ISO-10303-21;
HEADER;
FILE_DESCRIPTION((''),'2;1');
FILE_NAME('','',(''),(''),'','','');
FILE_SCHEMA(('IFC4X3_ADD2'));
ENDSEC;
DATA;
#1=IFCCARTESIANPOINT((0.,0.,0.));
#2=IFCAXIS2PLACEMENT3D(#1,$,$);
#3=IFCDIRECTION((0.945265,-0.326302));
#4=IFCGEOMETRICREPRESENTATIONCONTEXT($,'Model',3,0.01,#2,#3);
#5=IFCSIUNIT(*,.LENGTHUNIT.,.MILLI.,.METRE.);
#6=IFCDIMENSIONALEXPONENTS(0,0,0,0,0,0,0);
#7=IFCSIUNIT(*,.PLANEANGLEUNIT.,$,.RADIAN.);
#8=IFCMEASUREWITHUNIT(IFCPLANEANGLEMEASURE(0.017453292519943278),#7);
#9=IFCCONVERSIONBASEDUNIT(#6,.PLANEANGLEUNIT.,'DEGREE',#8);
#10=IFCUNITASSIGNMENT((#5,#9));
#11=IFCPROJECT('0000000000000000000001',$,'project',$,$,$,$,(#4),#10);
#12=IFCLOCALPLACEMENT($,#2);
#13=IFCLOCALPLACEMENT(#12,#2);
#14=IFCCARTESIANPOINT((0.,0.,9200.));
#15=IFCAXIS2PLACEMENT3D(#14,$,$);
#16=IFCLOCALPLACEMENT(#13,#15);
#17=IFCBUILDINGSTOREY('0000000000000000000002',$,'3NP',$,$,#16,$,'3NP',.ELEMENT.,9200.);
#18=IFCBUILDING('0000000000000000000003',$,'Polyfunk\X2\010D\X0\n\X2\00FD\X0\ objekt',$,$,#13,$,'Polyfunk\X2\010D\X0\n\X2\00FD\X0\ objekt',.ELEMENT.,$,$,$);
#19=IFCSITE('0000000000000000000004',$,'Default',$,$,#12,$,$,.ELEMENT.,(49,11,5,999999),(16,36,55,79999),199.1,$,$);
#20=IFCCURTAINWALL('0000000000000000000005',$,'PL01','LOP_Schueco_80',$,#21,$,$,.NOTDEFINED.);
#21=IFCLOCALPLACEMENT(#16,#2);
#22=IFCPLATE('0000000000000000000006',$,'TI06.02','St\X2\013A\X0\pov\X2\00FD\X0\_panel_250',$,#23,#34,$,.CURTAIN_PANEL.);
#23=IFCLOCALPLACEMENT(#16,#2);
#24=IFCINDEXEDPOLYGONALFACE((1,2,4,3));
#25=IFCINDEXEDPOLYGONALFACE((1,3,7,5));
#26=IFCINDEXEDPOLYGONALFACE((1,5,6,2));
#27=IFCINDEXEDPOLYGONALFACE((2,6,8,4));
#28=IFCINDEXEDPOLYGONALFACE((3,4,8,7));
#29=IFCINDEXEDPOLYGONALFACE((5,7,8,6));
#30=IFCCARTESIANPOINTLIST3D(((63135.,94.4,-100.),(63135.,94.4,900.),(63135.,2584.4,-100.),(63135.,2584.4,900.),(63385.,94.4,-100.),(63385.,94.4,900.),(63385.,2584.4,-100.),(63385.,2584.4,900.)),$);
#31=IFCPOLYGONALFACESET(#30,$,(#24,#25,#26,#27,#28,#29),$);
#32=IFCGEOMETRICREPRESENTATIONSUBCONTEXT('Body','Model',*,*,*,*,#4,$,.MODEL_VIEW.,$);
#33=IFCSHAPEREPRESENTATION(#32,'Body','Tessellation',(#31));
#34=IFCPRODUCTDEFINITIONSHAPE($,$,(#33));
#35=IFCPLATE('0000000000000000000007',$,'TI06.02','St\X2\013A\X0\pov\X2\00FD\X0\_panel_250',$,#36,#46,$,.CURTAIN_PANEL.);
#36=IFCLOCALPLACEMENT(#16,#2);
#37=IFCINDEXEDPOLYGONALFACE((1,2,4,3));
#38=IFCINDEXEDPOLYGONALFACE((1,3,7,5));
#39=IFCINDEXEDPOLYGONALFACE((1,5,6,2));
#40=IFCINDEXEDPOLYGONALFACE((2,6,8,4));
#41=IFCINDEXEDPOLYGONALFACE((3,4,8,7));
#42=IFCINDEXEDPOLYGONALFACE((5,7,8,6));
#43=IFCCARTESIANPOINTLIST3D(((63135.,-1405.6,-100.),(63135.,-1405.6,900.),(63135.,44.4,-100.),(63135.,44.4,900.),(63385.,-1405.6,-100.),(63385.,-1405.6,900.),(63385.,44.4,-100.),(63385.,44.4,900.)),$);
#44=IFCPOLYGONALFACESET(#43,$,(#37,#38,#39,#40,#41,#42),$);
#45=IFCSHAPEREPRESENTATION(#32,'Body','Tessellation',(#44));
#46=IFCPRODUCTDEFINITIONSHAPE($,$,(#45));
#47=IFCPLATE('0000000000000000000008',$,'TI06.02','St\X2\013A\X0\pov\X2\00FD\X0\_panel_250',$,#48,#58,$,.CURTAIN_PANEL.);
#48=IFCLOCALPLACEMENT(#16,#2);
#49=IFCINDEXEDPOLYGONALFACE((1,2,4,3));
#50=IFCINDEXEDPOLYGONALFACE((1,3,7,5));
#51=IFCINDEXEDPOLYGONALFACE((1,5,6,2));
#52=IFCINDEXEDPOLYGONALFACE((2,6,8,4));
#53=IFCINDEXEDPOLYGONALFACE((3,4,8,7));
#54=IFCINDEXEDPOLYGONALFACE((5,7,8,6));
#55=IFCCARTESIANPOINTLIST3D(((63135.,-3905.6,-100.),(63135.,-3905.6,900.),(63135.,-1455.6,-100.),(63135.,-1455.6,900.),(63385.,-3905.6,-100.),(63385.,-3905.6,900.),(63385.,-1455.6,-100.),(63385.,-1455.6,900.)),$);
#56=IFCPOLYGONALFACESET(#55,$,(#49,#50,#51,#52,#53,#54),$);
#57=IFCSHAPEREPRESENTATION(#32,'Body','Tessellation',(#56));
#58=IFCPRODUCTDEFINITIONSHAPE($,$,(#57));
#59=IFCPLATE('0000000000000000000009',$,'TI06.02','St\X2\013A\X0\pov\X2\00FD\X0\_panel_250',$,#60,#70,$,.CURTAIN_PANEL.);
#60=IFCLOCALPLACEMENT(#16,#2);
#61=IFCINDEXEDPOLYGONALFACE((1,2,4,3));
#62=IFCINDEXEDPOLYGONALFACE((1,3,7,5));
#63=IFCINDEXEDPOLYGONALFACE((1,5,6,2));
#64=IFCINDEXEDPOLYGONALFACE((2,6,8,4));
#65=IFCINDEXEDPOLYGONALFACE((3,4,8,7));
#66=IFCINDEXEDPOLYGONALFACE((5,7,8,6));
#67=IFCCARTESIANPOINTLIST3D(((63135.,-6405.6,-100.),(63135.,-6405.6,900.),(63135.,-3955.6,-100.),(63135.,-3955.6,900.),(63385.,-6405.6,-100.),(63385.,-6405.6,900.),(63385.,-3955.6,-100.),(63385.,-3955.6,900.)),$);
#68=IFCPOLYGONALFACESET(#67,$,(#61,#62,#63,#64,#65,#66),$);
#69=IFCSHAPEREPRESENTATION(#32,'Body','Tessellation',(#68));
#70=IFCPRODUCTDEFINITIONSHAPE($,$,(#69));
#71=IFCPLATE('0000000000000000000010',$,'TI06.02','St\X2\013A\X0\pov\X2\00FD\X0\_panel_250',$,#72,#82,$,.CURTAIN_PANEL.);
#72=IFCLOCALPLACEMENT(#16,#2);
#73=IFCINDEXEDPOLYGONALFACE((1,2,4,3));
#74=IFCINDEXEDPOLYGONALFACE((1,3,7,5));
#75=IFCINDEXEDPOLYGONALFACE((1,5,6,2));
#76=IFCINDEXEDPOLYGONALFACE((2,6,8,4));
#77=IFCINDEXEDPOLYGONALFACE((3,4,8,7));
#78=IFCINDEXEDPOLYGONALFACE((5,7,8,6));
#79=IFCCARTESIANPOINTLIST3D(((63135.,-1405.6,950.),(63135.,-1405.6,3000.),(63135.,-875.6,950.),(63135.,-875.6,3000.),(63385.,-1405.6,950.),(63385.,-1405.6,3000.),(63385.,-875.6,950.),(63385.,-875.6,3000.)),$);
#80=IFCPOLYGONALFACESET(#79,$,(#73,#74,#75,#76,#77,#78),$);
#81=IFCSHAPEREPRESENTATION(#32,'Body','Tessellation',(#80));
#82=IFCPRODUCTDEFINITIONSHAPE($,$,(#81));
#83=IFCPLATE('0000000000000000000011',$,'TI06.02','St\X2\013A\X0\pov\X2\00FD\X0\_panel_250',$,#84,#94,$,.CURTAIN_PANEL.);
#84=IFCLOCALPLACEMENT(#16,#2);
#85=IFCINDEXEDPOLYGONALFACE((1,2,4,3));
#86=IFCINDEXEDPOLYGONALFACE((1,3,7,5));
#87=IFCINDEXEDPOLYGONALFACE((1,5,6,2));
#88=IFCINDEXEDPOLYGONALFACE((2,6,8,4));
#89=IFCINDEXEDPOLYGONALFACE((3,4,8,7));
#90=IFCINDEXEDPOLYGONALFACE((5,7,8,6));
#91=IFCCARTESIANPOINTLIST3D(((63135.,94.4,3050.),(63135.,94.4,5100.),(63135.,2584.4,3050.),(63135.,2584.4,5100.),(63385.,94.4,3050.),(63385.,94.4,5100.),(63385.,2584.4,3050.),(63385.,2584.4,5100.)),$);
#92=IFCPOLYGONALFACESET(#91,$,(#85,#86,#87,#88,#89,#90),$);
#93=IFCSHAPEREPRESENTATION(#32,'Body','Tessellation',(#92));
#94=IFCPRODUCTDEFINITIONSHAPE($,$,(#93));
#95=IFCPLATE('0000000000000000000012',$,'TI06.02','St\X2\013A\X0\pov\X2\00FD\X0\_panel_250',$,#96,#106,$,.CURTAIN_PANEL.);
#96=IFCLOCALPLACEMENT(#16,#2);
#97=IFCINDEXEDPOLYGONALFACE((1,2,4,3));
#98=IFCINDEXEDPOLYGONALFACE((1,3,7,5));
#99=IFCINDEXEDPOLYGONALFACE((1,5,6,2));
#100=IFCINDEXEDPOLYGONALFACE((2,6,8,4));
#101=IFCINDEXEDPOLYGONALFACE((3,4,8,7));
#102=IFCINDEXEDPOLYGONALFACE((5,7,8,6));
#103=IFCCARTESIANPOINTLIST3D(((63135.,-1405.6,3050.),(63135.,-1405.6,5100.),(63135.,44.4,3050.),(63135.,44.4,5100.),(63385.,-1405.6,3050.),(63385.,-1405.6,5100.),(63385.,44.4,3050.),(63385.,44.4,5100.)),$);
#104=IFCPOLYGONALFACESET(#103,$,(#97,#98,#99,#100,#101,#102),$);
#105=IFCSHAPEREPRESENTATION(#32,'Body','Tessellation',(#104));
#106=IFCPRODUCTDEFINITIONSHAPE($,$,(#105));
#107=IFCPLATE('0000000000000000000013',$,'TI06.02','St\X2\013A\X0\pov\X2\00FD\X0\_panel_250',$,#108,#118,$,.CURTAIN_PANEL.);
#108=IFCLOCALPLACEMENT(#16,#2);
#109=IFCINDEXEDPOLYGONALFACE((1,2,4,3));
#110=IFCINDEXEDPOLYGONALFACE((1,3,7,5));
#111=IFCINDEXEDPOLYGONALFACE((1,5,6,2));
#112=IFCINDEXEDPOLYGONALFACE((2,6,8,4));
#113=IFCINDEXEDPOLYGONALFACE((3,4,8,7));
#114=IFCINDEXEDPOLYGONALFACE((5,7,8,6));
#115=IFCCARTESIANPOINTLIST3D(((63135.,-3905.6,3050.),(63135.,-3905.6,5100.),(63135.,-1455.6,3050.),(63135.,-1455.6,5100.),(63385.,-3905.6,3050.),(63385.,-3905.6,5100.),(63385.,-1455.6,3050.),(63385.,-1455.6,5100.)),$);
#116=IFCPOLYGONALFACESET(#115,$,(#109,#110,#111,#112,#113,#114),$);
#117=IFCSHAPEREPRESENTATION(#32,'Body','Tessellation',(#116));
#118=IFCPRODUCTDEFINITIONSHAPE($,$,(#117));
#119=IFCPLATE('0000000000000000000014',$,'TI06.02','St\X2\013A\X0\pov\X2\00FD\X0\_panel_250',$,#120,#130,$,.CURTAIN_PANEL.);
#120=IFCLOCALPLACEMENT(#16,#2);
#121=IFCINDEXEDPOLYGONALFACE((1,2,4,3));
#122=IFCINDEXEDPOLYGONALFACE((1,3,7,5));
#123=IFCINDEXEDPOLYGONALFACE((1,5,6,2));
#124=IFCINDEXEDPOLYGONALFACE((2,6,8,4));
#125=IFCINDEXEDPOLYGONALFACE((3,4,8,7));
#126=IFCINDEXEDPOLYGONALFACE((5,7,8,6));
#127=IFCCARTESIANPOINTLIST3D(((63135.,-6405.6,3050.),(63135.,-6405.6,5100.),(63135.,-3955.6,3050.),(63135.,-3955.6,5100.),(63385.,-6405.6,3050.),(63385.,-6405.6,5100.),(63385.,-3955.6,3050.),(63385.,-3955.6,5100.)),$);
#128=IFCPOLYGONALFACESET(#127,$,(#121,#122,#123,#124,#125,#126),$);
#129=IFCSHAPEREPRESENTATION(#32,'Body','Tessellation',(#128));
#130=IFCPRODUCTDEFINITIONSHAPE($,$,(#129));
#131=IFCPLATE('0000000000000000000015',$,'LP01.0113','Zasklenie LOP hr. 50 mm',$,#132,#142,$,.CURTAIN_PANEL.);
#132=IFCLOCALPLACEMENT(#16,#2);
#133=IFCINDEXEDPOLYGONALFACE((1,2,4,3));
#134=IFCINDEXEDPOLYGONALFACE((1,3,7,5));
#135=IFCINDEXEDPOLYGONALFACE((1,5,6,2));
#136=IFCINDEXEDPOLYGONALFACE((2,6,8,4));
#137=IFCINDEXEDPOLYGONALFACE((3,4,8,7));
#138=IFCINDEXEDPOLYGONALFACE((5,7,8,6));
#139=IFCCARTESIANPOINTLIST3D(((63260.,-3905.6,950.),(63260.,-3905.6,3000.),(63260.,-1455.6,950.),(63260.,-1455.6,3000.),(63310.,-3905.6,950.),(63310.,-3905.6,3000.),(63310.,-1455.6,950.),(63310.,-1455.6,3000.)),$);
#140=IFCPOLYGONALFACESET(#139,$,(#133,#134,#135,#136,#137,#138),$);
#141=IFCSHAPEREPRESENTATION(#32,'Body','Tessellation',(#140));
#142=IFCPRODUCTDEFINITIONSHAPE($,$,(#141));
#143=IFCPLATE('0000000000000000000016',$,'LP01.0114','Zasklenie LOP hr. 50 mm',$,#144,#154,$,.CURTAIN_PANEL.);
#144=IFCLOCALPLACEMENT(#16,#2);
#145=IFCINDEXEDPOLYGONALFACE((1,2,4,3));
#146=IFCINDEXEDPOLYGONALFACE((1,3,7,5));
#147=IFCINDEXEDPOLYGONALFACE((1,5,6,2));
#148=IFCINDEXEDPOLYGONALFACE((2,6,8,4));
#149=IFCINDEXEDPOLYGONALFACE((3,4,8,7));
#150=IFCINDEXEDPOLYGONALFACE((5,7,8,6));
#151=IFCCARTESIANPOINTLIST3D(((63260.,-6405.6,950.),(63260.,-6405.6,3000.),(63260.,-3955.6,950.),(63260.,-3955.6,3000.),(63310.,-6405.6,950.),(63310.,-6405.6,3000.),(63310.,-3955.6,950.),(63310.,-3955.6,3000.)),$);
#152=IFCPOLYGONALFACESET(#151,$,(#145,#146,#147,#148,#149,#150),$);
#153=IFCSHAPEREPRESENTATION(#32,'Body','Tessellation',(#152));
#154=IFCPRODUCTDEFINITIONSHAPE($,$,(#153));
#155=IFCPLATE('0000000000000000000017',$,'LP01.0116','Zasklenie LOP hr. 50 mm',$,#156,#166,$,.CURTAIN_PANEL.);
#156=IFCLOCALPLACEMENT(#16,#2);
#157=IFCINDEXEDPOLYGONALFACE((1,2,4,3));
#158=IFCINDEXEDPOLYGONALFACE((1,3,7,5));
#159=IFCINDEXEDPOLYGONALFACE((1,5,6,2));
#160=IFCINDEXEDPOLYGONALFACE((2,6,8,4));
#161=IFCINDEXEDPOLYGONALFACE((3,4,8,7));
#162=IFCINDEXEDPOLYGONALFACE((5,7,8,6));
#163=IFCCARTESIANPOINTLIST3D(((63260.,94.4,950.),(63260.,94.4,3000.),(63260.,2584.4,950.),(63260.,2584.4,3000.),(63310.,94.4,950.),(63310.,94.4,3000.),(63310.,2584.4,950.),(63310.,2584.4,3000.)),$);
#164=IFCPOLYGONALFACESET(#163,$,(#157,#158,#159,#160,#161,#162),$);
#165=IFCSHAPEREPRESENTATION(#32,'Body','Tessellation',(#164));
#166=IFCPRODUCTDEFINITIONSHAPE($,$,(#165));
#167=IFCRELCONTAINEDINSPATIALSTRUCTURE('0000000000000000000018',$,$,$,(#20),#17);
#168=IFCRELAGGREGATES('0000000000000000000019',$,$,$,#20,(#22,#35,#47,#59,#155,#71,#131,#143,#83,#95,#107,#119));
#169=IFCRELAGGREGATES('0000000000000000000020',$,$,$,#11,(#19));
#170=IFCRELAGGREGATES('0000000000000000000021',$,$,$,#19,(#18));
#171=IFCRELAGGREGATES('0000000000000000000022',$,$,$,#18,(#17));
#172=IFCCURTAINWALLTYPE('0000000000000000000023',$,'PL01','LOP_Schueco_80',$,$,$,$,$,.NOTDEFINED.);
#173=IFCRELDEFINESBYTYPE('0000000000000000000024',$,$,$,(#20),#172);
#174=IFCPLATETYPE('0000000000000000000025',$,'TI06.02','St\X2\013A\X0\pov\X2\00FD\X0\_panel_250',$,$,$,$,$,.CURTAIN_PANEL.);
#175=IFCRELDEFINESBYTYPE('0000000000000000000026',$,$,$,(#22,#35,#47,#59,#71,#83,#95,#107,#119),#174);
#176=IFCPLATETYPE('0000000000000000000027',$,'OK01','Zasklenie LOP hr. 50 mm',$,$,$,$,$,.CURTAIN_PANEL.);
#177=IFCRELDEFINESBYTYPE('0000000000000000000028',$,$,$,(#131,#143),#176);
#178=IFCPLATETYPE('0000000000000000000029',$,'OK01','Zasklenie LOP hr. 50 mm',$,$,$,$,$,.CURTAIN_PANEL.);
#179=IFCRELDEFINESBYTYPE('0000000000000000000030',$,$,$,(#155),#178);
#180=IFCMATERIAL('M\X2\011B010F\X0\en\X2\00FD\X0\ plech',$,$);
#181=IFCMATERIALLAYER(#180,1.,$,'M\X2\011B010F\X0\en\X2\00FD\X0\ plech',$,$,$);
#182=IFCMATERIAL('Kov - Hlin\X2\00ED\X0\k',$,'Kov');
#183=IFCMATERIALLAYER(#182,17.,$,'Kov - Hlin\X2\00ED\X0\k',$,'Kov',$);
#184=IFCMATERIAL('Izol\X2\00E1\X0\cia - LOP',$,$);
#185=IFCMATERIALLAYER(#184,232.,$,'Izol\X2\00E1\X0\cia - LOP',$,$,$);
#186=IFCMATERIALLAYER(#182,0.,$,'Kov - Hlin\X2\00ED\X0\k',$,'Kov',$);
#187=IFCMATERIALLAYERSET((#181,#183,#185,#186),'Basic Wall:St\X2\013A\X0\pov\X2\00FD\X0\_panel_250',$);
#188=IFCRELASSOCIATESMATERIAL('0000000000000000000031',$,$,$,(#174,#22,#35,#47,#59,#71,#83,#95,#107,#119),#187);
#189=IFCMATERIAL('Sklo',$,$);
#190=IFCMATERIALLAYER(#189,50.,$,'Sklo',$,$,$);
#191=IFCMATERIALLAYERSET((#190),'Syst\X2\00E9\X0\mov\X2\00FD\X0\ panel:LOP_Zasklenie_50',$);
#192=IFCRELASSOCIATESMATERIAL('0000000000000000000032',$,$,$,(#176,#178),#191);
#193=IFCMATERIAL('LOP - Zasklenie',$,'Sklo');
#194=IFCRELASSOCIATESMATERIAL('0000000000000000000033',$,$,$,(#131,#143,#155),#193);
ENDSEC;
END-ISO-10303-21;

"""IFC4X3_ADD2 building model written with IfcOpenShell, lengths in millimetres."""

from ifc_helpers import new_model, entity, si_unit, converted_unit, direction, frame, frame_2d, origin, origin_2d_with_axis, place, context, subcontext, project, spatial, rectangle, extrude, source, transform, mapped, material, layer, layer_set, layer_usage, type_object, type_shapes, element, aggregate, save


model = new_model("IFC4X3_ADD2")

# Units and contexts
model_context = context("Model", 3, precision=0.01, world=origin(), true_north=direction((0.945265, -0.326302)))
body_context = subcontext(model_context, "Body", "Model", "MODEL_VIEW")
ifc_project = project(units=[si_unit("LENGTHUNIT", "METRE", prefix="MILLI"), converted_unit("PLANEANGLEUNIT", "DEGREE", entity("IfcPlaneAngleMeasure", 0.017453292519943278), si_unit("PLANEANGLEUNIT", "RADIAN"), dimensions=[0, 0, 0, 0, 0, 0, 0])], contexts=[model_context])

# Site, building, storey
site_placement = place(None, origin())
site = spatial("IfcSite", under=ifc_project, at=site_placement, Name="Default", CompositionType="ELEMENT", RefLatitude=(49, 11, 5, 999999), RefLongitude=(16, 36, 55, 79999), RefElevation=199.1)
building_placement = place(site_placement, origin())
building = spatial("IfcBuilding", under=site, at=building_placement, Name="Polyfunkčný objekt", LongName="Polyfunkčný objekt", CompositionType="ELEMENT")
storey_placement = place(building_placement, frame((0.0, 0.0, 9200.0)))
storey = spatial("IfcBuildingStorey", under=building, at=storey_placement, Name="3NP", LongName="3NP", CompositionType="ELEMENT", Elevation=9200.0)

# Curtain wall, plates
curtain_wall_type = type_object("IfcCurtainWallType", Name="PL01", Description="LOP_Schueco_80", PredefinedType="NOTDEFINED")
curtain_wall_placement = place(storey_placement, frame((0.0, 0.0, -9200.0)))
curtain_wall = element("IfcCurtainWall", 1, at=curtain_wall_placement, inside=storey, type_object=curtain_wall_type, Name="PL01", Description="LOP_Schueco_80", PredefinedType="NOTDEFINED")
ifc_material_1 = material(Name="Měďený plech")
ifc_layer_1 = layer(ifc_material_1, 1.0, Name="Měďený plech")
ifc_material_2 = material(Name="Kov - Hliník", Category="Kov")
ifc_layer_2 = layer(ifc_material_2, 17.0, Name="Kov - Hliník", Category="Kov")
ifc_material_3 = material(Name="Izolácia - LOP")
ifc_layer_3 = layer(ifc_material_3, 232.0, Name="Izolácia - LOP")
ifc_layer_4 = layer(ifc_material_2, 0.0, Name="Kov - Hliník", Category="Kov")
ifc_layer_set_1 = layer_set([ifc_layer_1, ifc_layer_2, ifc_layer_3, ifc_layer_4], Name="Basic Wall:Stĺpový_panel_250")
ifc_layer_usage_1 = layer_usage(ifc_layer_set_1, "AXIS2", "NEGATIVE", 125.0)
plate_type_1 = type_object("IfcPlateType", Name="TI06.02", Description="Stĺpový_panel_250", PredefinedType="CURTAIN_PANEL", material=ifc_layer_set_1)
plate_1_placement = place(storey_placement, frame((63260.0, 2584.4, -100.0), z_axis=(0.0, 0.0, 1.0), x_axis=(0.0, -1.0, 0.0)))
plate_1 = element("IfcPlate", 2, at=plate_1_placement, type_object=plate_type_1, material=ifc_layer_usage_1, Name="TI06.02", Description="Stĺpový_panel_250", PredefinedType="CURTAIN_PANEL", context=body_context, shape_type="SweptSolid", body=[
    extrude(rectangle(XDim=250.0, YDim=2490.0, at=frame_2d((0.0, 0.0), x_axis=(1.0, 0.0))), frame((1245.0, 0.0, 0.0), z_axis=(0.0, 0.0, 1.0), x_axis=(0.0, 1.0, 0.0)), (0.0, 0.0, 1.0), 1000.0),
])
ifc_layer_usage_2 = layer_usage(ifc_layer_set_1, "AXIS2", "NEGATIVE", 125.0)
plate_2_placement = place(storey_placement, frame((63260.0, 44.4, -100.0), z_axis=(0.0, 0.0, 1.0), x_axis=(0.0, -1.0, 0.0)))
plate_2 = element("IfcPlate", 3, at=plate_2_placement, type_object=plate_type_1, material=ifc_layer_usage_2, Name="TI06.02", Description="Stĺpový_panel_250", PredefinedType="CURTAIN_PANEL", context=body_context, shape_type="SweptSolid", body=[
    extrude(rectangle(XDim=250.0, YDim=1450.0, at=frame_2d((0.0, 0.0), x_axis=(1.0, 0.0))), frame((725.0, 0.0, 0.0), z_axis=(0.0, 0.0, 1.0), x_axis=(0.0, 1.0, 0.0)), (0.0, 0.0, 1.0), 1000.0),
])
ifc_layer_usage_3 = layer_usage(ifc_layer_set_1, "AXIS2", "NEGATIVE", 125.0)
plate_3_placement = place(storey_placement, frame((63260.0, -1455.6, -100.0), z_axis=(0.0, 0.0, 1.0), x_axis=(0.0, -1.0, 0.0)))
plate_3 = element("IfcPlate", 4, at=plate_3_placement, type_object=plate_type_1, material=ifc_layer_usage_3, Name="TI06.02", Description="Stĺpový_panel_250", PredefinedType="CURTAIN_PANEL", context=body_context, shape_type="SweptSolid", body=[
    extrude(rectangle(XDim=250.0, YDim=2450.0, at=frame_2d((0.0, 0.0), x_axis=(1.0, 0.0))), frame((1225.0, 0.0, 0.0), z_axis=(0.0, 0.0, 1.0), x_axis=(0.0, 1.0, 0.0)), (0.0, 0.0, 1.0), 1000.0),
])
ifc_layer_usage_4 = layer_usage(ifc_layer_set_1, "AXIS2", "NEGATIVE", 125.0)
plate_4_placement = place(storey_placement, frame((63260.0, -3955.6, -100.0), z_axis=(0.0, 0.0, 1.0), x_axis=(0.0, -1.0, 0.0)))
plate_4 = element("IfcPlate", 5, at=plate_4_placement, type_object=plate_type_1, material=ifc_layer_usage_4, Name="TI06.02", Description="Stĺpový_panel_250", PredefinedType="CURTAIN_PANEL", context=body_context, shape_type="SweptSolid", body=[
    extrude(rectangle(XDim=250.0, YDim=2450.0, at=frame_2d((0.0, 0.0), x_axis=(1.0, 0.0))), frame((1225.0, 0.0, 0.0), z_axis=(0.0, 0.0, 1.0), x_axis=(0.0, 1.0, 0.0)), (0.0, 0.0, 1.0), 1000.0),
])
ifc_layer_usage_5 = layer_usage(ifc_layer_set_1, "AXIS2", "NEGATIVE", 125.0)
plate_5_placement = place(storey_placement, frame((63260.0, -875.6, 950.0), z_axis=(0.0, 0.0, 1.0), x_axis=(0.0, -1.0, 0.0)))
plate_5 = element("IfcPlate", 6, at=plate_5_placement, type_object=plate_type_1, material=ifc_layer_usage_5, Name="TI06.02", Description="Stĺpový_panel_250", PredefinedType="CURTAIN_PANEL", context=body_context, shape_type="SweptSolid", body=[
    extrude(rectangle(XDim=250.0, YDim=530.0, at=frame_2d((0.0, 0.0), x_axis=(1.0, 0.0))), frame((265.0, 0.0, 0.0), z_axis=(0.0, 0.0, 1.0), x_axis=(0.0, 1.0, 0.0)), (0.0, 0.0, 1.0), 2050.0),
])
ifc_layer_usage_6 = layer_usage(ifc_layer_set_1, "AXIS2", "NEGATIVE", 125.0)
plate_6_placement = place(storey_placement, frame((63260.0, 2584.4, 3050.0), z_axis=(0.0, 0.0, 1.0), x_axis=(0.0, -1.0, 0.0)))
plate_6 = element("IfcPlate", 7, at=plate_6_placement, type_object=plate_type_1, material=ifc_layer_usage_6, Name="TI06.02", Description="Stĺpový_panel_250", PredefinedType="CURTAIN_PANEL", context=body_context, shape_type="SweptSolid", body=[
    extrude(rectangle(XDim=250.0, YDim=2490.0, at=frame_2d((0.0, 0.0), x_axis=(1.0, 0.0))), frame((1245.0, 0.0, 0.0), z_axis=(0.0, 0.0, 1.0), x_axis=(0.0, 1.0, 0.0)), (0.0, 0.0, 1.0), 2050.0),
])
ifc_layer_usage_7 = layer_usage(ifc_layer_set_1, "AXIS2", "NEGATIVE", 125.0)
plate_7_placement = place(storey_placement, frame((63260.0, 44.4, 3050.0), z_axis=(0.0, 0.0, 1.0), x_axis=(0.0, -1.0, 0.0)))
plate_7 = element("IfcPlate", 8, at=plate_7_placement, type_object=plate_type_1, material=ifc_layer_usage_7, Name="TI06.02", Description="Stĺpový_panel_250", PredefinedType="CURTAIN_PANEL", context=body_context, shape_type="SweptSolid", body=[
    extrude(rectangle(XDim=250.0, YDim=1450.0, at=frame_2d((0.0, 0.0), x_axis=(1.0, 0.0))), frame((725.0, 0.0, 0.0), z_axis=(0.0, 0.0, 1.0), x_axis=(0.0, 1.0, 0.0)), (0.0, 0.0, 1.0), 2050.0),
])
ifc_layer_usage_8 = layer_usage(ifc_layer_set_1, "AXIS2", "NEGATIVE", 125.0)
plate_8_placement = place(storey_placement, frame((63260.0, -1455.6, 3050.0), z_axis=(0.0, 0.0, 1.0), x_axis=(0.0, -1.0, 0.0)))
plate_8 = element("IfcPlate", 9, at=plate_8_placement, type_object=plate_type_1, material=ifc_layer_usage_8, Name="TI06.02", Description="Stĺpový_panel_250", PredefinedType="CURTAIN_PANEL", context=body_context, shape_type="SweptSolid", body=[
    extrude(rectangle(XDim=250.0, YDim=2450.0, at=frame_2d((0.0, 0.0), x_axis=(1.0, 0.0))), frame((1225.0, 0.0, 0.0), z_axis=(0.0, 0.0, 1.0), x_axis=(0.0, 1.0, 0.0)), (0.0, 0.0, 1.0), 2050.0),
])
ifc_layer_usage_9 = layer_usage(ifc_layer_set_1, "AXIS2", "NEGATIVE", 125.0)
plate_9_placement = place(storey_placement, frame((63260.0, -3955.6, 3050.0), z_axis=(0.0, 0.0, 1.0), x_axis=(0.0, -1.0, 0.0)))
plate_9 = element("IfcPlate", 10, at=plate_9_placement, type_object=plate_type_1, material=ifc_layer_usage_9, Name="TI06.02", Description="Stĺpový_panel_250", PredefinedType="CURTAIN_PANEL", context=body_context, shape_type="SweptSolid", body=[
    extrude(rectangle(XDim=250.0, YDim=2450.0, at=frame_2d((0.0, 0.0), x_axis=(1.0, 0.0))), frame((1225.0, 0.0, 0.0), z_axis=(0.0, 0.0, 1.0), x_axis=(0.0, 1.0, 0.0)), (0.0, 0.0, 1.0), 2050.0),
])
ifc_material_4 = material(Name="LOP - Zasklenie", Category="Sklo")
ifc_material_5 = material(Name="Sklo")
ifc_layer_5 = layer(ifc_material_5, 50.0, Name="Sklo")
ifc_layer_set_2 = layer_set([ifc_layer_5], Name="Systémový panel:LOP_Zasklenie_50")
plate_type_2 = type_object("IfcPlateType", Name="OK01", Description="Zasklenie LOP hr. 50 mm", PredefinedType="CURTAIN_PANEL", material=ifc_layer_set_2)
shared_shape_1 = source(origin(), body_context, "Body", "SweptSolid", [
    extrude(rectangle(XDim=50.0, YDim=2450.0, at=origin_2d_with_axis()), frame((0.0, 25.0, 0.0), z_axis=(0.0, 0.0, 1.0), x_axis=(0.0, 1.0, 0.0)), (0.0, 0.0, 1.0), 2050.0),
])
type_shapes(plate_type_2, [shared_shape_1])
plate_10_placement = place(curtain_wall_placement, frame((63260.0, -2680.6, 10150.0), z_axis=(0.0, 0.0, 1.0), x_axis=(0.0, -1.0, 0.0)))
plate_10 = element("IfcPlate", 11, at=plate_10_placement, type_object=plate_type_2, material=ifc_material_4, Name="LP01.0113", Description="Zasklenie LOP hr. 50 mm", PredefinedType="CURTAIN_PANEL", context=body_context, shape_type="MappedRepresentation", body=[
    mapped(shared_shape_1, transform((0.0, 0.0, 0.0), scale=1.0)),
])
plate_11_placement = place(curtain_wall_placement, frame((63260.0, -5180.6, 10150.0), z_axis=(0.0, 0.0, 1.0), x_axis=(0.0, -1.0, 0.0)))
plate_11 = element("IfcPlate", 12, at=plate_11_placement, type_object=plate_type_2, material=ifc_material_4, Name="LP01.0114", Description="Zasklenie LOP hr. 50 mm", PredefinedType="CURTAIN_PANEL", context=body_context, shape_type="MappedRepresentation", body=[
    mapped(shared_shape_1, transform((0.0, 0.0, 0.0), scale=1.0)),
])
plate_type_3 = type_object("IfcPlateType", Name="OK01", Description="Zasklenie LOP hr. 50 mm", PredefinedType="CURTAIN_PANEL", material=ifc_layer_set_2)
shared_shape_2 = source(origin(), body_context, "Body", "SweptSolid", [
    extrude(rectangle(XDim=50.0, YDim=2490.0, at=origin_2d_with_axis()), frame((0.0, 25.0, 0.0), z_axis=(0.0, 0.0, 1.0), x_axis=(0.0, 1.0, 0.0)), (0.0, 0.0, 1.0), 2050.0),
])
type_shapes(plate_type_3, [shared_shape_2])
plate_12_placement = place(curtain_wall_placement, frame((63260.0, 1339.4, 10150.0), z_axis=(0.0, 0.0, 1.0), x_axis=(0.0, -1.0, 0.0)))
plate_12 = element("IfcPlate", 13, at=plate_12_placement, type_object=plate_type_3, material=ifc_material_4, Name="LP01.0116", Description="Zasklenie LOP hr. 50 mm", PredefinedType="CURTAIN_PANEL", context=body_context, shape_type="MappedRepresentation", body=[
    mapped(shared_shape_2, transform((0.0, 0.0, 0.0), scale=1.0)),
])
aggregate(curtain_wall, [plate_1, plate_2, plate_3, plate_4, plate_12, plate_5, plate_10, plate_11, plate_6, plate_7, plate_8, plate_9])

save(model, "model.ifc")
